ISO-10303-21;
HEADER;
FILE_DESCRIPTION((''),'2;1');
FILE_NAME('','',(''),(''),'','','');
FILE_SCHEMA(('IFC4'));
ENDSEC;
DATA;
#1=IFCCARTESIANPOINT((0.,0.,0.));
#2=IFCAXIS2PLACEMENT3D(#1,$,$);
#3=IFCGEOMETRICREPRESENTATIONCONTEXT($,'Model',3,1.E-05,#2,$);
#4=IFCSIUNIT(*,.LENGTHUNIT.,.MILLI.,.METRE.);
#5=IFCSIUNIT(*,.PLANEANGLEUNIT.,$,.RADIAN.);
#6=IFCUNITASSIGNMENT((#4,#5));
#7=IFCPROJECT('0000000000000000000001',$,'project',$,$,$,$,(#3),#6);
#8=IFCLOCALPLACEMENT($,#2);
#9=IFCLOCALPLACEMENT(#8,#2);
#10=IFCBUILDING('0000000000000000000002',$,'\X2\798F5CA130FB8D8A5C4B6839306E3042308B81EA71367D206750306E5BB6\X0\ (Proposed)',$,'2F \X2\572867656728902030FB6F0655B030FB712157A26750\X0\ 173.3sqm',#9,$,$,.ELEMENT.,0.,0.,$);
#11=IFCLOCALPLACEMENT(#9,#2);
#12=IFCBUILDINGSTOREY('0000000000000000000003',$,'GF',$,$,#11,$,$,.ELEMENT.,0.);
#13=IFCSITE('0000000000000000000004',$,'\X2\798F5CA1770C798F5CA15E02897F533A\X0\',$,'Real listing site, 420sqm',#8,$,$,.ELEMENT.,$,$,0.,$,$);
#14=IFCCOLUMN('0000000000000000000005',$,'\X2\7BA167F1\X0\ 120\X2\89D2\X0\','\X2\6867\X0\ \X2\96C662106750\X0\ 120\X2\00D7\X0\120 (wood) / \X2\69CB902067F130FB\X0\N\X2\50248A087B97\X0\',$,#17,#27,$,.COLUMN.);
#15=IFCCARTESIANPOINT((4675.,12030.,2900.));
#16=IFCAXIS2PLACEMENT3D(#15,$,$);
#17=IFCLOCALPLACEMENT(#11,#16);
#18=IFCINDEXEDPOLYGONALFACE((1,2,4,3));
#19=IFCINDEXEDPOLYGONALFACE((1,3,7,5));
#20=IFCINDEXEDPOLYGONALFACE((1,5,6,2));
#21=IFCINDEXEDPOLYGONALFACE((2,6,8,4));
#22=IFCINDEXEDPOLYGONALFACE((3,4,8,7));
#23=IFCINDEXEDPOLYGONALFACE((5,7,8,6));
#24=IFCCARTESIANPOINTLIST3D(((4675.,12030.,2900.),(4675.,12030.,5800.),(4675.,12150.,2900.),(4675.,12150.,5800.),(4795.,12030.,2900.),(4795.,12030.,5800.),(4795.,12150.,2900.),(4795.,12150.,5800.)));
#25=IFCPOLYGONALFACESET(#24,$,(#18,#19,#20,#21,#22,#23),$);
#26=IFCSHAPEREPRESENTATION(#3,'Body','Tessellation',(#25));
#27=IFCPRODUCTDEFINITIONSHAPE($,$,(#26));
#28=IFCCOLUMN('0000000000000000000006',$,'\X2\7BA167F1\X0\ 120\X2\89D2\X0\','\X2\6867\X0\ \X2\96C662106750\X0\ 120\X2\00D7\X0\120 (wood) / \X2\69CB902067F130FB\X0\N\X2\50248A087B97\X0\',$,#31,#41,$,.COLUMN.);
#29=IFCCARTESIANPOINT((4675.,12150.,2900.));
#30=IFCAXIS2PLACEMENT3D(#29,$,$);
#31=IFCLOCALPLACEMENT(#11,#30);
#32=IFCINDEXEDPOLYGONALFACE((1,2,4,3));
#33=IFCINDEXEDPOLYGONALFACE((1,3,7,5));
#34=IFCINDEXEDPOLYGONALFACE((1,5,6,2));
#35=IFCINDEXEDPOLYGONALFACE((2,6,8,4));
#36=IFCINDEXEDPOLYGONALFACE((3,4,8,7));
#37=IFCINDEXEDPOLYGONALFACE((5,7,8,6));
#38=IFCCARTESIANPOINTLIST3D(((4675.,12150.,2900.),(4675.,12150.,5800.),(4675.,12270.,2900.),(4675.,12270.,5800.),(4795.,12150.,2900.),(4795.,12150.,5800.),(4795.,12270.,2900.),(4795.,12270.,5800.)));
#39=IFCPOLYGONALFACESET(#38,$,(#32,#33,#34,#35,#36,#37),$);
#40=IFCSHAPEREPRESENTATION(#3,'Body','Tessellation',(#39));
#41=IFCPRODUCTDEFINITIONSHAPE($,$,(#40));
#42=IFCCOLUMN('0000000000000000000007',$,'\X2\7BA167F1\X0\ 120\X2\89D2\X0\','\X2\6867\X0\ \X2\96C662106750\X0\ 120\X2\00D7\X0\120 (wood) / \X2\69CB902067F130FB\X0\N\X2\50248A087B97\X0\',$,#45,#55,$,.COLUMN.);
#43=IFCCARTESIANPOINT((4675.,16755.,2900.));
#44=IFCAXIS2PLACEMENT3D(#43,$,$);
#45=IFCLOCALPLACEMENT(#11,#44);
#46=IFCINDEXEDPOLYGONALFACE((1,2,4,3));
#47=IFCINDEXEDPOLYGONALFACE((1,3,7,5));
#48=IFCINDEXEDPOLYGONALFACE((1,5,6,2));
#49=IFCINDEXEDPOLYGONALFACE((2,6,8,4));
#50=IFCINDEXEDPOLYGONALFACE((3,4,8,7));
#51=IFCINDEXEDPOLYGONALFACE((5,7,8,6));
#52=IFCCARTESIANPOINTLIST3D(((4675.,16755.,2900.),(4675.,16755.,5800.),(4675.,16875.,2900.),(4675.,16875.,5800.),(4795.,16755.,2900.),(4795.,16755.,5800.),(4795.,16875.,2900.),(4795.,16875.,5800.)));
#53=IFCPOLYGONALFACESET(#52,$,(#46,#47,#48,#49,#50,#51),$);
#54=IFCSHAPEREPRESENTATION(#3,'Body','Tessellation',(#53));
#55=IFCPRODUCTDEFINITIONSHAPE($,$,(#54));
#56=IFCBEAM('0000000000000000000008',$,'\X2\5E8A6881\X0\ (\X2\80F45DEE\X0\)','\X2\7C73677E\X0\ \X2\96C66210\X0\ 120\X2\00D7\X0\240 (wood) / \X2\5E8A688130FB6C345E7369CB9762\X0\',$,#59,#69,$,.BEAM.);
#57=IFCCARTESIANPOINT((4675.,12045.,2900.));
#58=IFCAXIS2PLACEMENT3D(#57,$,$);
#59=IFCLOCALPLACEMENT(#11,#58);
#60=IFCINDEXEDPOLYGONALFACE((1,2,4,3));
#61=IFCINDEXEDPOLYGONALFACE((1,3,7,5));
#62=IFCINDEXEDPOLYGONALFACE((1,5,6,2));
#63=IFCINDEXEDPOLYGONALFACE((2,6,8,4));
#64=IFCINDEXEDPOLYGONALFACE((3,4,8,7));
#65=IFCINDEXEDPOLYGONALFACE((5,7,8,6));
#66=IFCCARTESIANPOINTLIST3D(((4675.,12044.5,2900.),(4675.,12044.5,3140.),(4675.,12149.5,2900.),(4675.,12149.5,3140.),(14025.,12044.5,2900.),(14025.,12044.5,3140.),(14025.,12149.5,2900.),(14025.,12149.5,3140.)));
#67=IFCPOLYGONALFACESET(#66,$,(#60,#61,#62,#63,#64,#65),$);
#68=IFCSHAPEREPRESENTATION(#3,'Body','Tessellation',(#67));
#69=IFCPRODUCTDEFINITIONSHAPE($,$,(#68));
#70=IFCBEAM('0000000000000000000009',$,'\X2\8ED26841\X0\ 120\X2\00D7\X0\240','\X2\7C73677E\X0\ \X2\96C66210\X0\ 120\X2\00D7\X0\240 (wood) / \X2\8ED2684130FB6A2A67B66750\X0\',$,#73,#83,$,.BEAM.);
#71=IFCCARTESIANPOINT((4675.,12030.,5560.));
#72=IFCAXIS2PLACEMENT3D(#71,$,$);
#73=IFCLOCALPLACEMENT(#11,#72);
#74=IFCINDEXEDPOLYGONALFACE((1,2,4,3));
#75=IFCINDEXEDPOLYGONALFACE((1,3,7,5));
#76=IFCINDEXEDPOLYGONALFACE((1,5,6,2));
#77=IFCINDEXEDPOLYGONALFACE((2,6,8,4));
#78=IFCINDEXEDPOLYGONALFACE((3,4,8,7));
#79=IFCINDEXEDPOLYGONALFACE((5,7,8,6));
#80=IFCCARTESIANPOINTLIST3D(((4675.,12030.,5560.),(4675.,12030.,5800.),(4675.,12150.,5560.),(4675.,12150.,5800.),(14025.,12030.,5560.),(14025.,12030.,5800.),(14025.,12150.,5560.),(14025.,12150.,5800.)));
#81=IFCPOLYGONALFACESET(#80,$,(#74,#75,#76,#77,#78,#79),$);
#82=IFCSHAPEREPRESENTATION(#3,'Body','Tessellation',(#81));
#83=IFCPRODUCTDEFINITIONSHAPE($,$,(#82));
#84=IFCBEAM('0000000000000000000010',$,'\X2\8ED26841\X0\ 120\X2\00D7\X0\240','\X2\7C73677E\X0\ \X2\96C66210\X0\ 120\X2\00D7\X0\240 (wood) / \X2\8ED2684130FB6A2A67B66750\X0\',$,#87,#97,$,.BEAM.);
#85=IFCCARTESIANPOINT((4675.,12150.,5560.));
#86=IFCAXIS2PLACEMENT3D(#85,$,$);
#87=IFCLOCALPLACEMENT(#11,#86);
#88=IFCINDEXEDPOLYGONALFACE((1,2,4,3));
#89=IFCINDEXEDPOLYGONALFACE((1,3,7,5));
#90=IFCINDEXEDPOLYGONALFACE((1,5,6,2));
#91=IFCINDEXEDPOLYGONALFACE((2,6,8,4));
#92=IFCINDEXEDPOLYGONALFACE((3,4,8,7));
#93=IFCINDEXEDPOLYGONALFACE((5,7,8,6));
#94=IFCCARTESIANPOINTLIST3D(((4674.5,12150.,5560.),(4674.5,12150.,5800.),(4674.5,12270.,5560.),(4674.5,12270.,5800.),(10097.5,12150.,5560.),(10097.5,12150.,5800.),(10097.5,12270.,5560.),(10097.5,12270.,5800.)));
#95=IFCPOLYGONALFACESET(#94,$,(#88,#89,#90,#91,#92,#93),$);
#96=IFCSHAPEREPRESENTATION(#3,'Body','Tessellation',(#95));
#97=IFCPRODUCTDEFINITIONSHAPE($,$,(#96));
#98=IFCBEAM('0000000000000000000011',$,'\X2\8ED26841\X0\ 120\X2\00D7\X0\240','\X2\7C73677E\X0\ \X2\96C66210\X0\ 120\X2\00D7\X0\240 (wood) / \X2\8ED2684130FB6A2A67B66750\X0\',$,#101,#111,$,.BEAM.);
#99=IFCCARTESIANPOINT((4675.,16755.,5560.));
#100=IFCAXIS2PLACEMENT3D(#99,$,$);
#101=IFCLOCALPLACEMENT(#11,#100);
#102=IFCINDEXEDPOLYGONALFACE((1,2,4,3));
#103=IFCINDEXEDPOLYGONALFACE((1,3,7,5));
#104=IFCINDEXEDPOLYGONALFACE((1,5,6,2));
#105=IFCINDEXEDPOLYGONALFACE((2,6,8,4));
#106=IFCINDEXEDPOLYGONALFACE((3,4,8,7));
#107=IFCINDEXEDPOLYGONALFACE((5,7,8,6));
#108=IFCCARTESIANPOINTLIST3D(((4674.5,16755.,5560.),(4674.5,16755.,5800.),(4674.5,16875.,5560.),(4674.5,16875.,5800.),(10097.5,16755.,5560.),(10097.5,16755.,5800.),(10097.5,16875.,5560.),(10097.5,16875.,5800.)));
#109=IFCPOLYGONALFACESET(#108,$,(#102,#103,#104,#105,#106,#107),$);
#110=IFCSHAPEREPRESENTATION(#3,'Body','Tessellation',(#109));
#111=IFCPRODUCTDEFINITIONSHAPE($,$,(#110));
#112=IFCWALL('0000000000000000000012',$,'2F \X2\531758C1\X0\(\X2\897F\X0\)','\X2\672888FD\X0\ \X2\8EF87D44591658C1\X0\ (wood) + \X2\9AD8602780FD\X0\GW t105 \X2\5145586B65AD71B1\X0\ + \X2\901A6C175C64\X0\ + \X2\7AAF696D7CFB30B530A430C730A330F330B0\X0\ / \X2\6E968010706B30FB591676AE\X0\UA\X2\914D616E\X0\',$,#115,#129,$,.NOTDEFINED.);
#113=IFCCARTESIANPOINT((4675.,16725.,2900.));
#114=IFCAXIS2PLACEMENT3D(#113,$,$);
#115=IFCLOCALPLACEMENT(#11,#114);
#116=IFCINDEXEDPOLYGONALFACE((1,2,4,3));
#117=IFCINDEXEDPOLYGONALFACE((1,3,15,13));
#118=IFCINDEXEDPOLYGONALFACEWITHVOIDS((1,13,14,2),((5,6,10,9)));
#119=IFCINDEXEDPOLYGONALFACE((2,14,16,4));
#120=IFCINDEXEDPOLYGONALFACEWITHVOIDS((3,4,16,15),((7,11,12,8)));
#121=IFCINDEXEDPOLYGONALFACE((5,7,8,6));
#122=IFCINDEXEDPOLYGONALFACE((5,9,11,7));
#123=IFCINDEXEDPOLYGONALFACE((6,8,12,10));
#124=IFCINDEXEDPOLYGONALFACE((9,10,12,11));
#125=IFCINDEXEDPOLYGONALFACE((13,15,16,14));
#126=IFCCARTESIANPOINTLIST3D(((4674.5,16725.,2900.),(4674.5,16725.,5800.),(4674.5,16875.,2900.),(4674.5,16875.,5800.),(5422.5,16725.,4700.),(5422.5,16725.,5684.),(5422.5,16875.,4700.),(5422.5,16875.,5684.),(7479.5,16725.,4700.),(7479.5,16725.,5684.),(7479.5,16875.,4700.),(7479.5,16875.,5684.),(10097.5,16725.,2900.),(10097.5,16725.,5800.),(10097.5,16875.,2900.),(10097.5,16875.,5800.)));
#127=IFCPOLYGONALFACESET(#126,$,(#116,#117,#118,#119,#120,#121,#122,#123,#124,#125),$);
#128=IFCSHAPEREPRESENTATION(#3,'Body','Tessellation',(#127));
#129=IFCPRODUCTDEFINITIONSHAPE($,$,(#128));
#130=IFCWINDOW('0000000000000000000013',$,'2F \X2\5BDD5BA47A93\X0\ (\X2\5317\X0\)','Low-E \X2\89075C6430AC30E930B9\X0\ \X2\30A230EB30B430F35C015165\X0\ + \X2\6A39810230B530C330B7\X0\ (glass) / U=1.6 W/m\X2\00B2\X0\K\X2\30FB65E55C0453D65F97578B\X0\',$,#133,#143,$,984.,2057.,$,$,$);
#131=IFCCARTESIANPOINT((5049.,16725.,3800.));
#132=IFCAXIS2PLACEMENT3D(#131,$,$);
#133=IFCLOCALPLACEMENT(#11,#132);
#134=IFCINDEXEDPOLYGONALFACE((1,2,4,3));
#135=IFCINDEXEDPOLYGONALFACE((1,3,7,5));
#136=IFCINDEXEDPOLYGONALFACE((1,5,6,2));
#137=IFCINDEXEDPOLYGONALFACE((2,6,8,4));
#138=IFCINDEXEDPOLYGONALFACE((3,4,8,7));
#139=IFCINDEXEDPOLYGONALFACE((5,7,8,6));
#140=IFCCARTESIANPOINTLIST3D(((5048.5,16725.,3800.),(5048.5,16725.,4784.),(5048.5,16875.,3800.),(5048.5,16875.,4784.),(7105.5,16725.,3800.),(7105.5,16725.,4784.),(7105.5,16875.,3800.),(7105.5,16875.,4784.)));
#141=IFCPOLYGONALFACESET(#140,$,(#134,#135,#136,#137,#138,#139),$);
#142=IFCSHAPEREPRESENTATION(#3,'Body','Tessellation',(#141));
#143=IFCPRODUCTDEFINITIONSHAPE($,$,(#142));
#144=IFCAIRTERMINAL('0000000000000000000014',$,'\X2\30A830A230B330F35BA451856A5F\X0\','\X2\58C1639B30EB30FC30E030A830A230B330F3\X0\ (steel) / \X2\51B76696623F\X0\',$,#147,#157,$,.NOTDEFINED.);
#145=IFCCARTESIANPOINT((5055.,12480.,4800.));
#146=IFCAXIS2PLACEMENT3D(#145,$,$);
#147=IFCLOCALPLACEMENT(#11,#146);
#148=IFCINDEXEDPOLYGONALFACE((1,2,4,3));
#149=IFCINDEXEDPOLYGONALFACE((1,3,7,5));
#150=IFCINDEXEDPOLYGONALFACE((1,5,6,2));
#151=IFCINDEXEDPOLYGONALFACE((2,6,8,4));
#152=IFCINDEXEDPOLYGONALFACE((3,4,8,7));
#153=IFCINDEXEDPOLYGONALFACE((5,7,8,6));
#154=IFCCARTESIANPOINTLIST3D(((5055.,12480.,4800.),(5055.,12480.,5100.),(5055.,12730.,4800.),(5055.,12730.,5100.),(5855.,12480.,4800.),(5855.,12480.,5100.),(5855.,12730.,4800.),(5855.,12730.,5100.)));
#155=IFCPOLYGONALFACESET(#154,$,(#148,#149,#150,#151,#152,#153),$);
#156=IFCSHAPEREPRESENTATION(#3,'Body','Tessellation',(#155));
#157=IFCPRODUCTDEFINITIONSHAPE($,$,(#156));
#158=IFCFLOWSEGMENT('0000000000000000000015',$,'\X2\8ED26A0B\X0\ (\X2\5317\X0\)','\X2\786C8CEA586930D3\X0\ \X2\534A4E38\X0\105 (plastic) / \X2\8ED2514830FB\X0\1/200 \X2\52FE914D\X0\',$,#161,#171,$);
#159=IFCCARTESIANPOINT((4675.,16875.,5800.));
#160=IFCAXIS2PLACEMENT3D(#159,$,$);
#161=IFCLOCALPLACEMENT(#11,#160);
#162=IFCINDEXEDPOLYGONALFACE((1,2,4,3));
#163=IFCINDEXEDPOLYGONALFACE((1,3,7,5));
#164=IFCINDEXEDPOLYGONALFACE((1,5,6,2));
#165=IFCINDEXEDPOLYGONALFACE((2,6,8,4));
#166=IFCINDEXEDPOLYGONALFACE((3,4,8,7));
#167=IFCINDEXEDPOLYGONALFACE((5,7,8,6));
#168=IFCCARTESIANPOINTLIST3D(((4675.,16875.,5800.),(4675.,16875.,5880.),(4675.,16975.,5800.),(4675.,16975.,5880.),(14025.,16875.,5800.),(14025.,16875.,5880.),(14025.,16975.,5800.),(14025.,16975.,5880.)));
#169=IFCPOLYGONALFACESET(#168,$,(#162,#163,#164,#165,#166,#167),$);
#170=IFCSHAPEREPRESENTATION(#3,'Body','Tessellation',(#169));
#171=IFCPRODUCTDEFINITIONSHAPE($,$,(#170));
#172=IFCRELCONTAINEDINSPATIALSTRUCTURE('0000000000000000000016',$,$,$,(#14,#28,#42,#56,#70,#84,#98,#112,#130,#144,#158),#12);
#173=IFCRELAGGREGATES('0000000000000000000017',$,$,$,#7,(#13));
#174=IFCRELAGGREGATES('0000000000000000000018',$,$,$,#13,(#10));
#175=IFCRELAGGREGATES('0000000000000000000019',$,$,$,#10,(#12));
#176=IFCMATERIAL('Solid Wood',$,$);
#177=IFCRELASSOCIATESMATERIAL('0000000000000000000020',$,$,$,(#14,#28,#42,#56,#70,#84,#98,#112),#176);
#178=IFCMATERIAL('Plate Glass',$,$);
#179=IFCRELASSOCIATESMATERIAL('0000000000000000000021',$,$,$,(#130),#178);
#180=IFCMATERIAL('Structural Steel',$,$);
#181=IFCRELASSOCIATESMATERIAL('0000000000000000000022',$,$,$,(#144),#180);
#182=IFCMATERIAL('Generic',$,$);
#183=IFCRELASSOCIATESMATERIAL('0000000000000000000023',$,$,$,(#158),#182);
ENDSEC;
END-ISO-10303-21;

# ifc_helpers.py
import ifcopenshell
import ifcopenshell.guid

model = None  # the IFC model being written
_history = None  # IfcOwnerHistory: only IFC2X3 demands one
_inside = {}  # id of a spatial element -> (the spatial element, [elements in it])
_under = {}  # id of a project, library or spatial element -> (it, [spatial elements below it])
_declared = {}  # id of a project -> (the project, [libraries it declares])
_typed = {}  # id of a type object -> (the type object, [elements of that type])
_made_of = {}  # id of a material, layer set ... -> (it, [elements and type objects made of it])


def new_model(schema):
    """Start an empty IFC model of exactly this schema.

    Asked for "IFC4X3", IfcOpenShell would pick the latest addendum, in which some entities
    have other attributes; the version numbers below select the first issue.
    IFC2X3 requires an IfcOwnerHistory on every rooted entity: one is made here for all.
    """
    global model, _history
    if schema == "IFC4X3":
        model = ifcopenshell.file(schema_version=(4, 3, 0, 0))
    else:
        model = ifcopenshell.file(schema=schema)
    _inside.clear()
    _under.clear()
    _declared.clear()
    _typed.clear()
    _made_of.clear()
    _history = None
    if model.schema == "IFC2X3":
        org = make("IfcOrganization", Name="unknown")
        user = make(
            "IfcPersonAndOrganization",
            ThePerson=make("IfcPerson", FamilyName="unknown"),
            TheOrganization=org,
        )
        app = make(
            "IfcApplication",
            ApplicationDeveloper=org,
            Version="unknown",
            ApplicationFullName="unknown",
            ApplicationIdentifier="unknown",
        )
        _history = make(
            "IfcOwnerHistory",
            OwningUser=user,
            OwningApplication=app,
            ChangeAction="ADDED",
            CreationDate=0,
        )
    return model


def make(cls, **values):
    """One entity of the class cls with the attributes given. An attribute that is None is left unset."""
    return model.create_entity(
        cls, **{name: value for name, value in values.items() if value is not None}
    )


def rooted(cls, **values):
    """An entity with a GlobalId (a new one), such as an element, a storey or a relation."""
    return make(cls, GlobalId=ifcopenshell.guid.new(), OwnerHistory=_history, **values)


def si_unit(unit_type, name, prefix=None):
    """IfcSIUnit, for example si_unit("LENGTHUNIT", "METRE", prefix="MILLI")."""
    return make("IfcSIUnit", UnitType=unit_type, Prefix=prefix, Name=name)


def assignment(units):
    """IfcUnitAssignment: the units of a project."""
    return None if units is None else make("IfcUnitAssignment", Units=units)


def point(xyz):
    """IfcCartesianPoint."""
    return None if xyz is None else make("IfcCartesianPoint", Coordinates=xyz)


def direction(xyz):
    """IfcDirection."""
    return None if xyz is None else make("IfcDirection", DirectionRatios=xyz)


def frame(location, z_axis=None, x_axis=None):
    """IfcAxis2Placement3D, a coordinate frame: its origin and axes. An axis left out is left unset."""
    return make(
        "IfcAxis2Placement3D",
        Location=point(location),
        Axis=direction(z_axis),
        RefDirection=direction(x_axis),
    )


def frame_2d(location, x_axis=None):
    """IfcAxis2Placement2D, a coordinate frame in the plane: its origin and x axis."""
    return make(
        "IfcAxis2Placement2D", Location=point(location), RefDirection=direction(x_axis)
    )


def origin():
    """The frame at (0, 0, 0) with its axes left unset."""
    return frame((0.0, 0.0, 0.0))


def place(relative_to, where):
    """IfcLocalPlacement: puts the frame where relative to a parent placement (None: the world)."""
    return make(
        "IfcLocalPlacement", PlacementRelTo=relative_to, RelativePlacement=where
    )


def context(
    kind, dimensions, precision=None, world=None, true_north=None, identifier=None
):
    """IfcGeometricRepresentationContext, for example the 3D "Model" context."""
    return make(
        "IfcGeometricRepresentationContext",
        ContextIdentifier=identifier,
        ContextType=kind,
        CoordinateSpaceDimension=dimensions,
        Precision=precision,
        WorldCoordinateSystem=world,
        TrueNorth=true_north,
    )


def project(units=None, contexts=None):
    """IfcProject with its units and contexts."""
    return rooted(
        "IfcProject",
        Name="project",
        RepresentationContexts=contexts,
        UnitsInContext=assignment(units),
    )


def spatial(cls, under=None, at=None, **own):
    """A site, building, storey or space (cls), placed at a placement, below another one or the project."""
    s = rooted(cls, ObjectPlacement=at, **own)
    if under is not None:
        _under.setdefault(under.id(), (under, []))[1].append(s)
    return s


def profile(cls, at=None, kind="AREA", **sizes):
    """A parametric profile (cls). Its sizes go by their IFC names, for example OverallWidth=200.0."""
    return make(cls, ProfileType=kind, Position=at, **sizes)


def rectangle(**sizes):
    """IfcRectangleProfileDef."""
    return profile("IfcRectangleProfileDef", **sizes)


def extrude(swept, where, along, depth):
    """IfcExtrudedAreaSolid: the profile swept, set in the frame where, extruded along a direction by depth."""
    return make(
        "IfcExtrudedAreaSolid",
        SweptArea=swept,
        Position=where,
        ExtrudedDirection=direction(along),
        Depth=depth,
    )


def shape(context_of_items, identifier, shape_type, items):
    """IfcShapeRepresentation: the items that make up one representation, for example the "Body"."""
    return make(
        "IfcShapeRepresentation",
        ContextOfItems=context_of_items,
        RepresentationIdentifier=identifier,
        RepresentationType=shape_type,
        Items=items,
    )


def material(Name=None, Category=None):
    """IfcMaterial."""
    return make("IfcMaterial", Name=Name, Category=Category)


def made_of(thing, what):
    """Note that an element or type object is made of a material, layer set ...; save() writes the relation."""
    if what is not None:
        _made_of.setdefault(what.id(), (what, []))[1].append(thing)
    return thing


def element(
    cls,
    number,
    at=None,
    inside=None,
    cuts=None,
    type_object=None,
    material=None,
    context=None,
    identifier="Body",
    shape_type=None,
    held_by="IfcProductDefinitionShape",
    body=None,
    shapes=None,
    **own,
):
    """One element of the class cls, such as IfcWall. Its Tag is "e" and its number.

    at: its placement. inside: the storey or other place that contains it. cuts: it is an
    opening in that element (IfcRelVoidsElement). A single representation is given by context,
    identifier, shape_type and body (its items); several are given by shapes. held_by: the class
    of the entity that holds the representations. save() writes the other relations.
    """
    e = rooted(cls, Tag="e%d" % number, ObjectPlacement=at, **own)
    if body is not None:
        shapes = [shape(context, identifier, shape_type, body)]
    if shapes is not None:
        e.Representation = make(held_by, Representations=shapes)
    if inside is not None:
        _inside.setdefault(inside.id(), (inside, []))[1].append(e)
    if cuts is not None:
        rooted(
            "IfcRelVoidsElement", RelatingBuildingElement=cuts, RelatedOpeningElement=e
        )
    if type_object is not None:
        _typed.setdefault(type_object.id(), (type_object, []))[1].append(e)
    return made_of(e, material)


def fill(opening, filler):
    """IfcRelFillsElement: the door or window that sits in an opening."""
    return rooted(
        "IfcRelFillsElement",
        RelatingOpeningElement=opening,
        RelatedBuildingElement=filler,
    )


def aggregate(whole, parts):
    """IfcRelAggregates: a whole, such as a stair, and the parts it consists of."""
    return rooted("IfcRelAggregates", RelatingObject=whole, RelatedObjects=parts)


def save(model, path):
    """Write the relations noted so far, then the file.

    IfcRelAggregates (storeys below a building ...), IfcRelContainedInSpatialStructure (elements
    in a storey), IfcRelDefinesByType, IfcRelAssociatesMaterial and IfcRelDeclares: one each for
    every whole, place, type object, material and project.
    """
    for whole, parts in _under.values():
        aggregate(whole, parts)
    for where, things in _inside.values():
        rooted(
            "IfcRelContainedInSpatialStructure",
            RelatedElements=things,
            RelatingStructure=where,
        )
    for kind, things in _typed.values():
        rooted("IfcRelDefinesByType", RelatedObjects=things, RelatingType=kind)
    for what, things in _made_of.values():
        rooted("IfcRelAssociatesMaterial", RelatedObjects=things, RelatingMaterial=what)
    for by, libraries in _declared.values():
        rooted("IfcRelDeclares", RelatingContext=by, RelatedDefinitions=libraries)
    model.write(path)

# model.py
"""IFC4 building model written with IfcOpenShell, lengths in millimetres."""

from ifc_helpers import new_model, si_unit, frame, frame_2d, origin, place, context, project, spatial, rectangle, extrude, material, element, fill, save


model = new_model("IFC4")

# Units and contexts
model_context = context("Model", 3, precision=1e-05, world=origin())
ifc_project = project(units=[si_unit("LENGTHUNIT", "METRE", prefix="MILLI"), si_unit("PLANEANGLEUNIT", "RADIAN")], contexts=[model_context])

# Site, building, storey
site_placement = place(None, origin())
site = spatial("IfcSite", under=ifc_project, at=site_placement, Name="福岡県福岡市西区", ObjectType="Real listing site, 420sqm", CompositionType="ELEMENT", RefElevation=0.0)
building_placement = place(site_placement, origin())
building = spatial("IfcBuilding", under=site, at=building_placement, Name="福岡・越屋根のある自然素材の家 (Proposed)", ObjectType="2F 在来木造・漆喰・無垢材 173.3sqm", CompositionType="ELEMENT", ElevationOfRefHeight=0.0, ElevationOfTerrain=0.0)
storey_placement = place(building_placement, origin())
storey = spatial("IfcBuildingStorey", under=building, at=storey_placement, Name="GF", CompositionType="ELEMENT", Elevation=0.0)

# Columns
ifc_material_1 = material(Name="Solid Wood")
column_1_placement = place(storey_placement, frame((4675.0, 12030.0, 2900.0)))
element("IfcColumn", 1, at=column_1_placement, inside=storey, material=ifc_material_1, Name="管柱 120角", Description="桧 集成材 120×120 (wood) / 構造柱・N値計算", PredefinedType="COLUMN", context=model_context, shape_type="SweptSolid", body=[
    extrude(rectangle(XDim=120.0, YDim=120.0, at=frame_2d((60.0, 60.0))), frame((4675.0, 12030.0, 2900.0)), (0.0, 0.0, 1.0), 2900.0),
])
column_2_placement = place(storey_placement, frame((4675.0, 12150.0, 2900.0)))
element("IfcColumn", 2, at=column_2_placement, inside=storey, material=ifc_material_1, Name="管柱 120角", Description="桧 集成材 120×120 (wood) / 構造柱・N値計算", PredefinedType="COLUMN", context=model_context, shape_type="SweptSolid", body=[
    extrude(rectangle(XDim=120.0, YDim=120.0, at=frame_2d((60.0, 60.0))), frame((4675.0, 12150.0, 2900.0)), (0.0, 0.0, 1.0), 2900.0),
])
column_3_placement = place(storey_placement, frame((4675.0, 16755.0, 2900.0)))
element("IfcColumn", 3, at=column_3_placement, inside=storey, material=ifc_material_1, Name="管柱 120角", Description="桧 集成材 120×120 (wood) / 構造柱・N値計算", PredefinedType="COLUMN", context=model_context, shape_type="SweptSolid", body=[
    extrude(rectangle(XDim=120.0, YDim=120.0, at=frame_2d((60.0, 60.0))), frame((4675.0, 16755.0, 2900.0)), (0.0, 0.0, 1.0), 2900.0),
])

# Beams
beam_1_placement = place(storey_placement, frame((4675.0, 12045.0, 2900.0)))
element("IfcBeam", 4, at=beam_1_placement, inside=storey, material=ifc_material_1, Name="床梁 (胴差)", Description="米松 集成 120×240 (wood) / 床梁・水平構面", PredefinedType="BEAM", context=model_context, shape_type="SweptSolid", body=[
    extrude(rectangle(XDim=9350.0, YDim=105.0, at=frame_2d((4675.0, 52.0))), frame((4675.0, 12045.0, 2900.0)), (0.0, 0.0, 1.0), 240.0),
])
beam_2_placement = place(storey_placement, frame((4675.0, 12030.0, 5560.0)))
element("IfcBeam", 5, at=beam_2_placement, inside=storey, material=ifc_material_1, Name="軒桁 120×240", Description="米松 集成 120×240 (wood) / 軒桁・横架材", PredefinedType="BEAM", context=model_context, shape_type="SweptSolid", body=[
    extrude(rectangle(XDim=9350.0, YDim=120.0, at=frame_2d((4675.0, 60.0))), frame((4675.0, 12030.0, 5560.0)), (0.0, 0.0, 1.0), 240.0),
])
beam_3_placement = place(storey_placement, frame((4675.0, 12150.0, 5560.0)))
element("IfcBeam", 6, at=beam_3_placement, inside=storey, material=ifc_material_1, Name="軒桁 120×240", Description="米松 集成 120×240 (wood) / 軒桁・横架材", PredefinedType="BEAM", context=model_context, shape_type="SweptSolid", body=[
    extrude(rectangle(XDim=5423.0, YDim=120.0, at=frame_2d((2711.0, 60.0))), frame((4675.0, 12150.0, 5560.0)), (0.0, 0.0, 1.0), 240.0),
])
beam_4_placement = place(storey_placement, frame((4675.0, 16755.0, 5560.0)))
element("IfcBeam", 7, at=beam_4_placement, inside=storey, material=ifc_material_1, Name="軒桁 120×240", Description="米松 集成 120×240 (wood) / 軒桁・横架材", PredefinedType="BEAM", context=model_context, shape_type="SweptSolid", body=[
    extrude(rectangle(XDim=5423.0, YDim=120.0, at=frame_2d((2711.0, 60.0))), frame((4675.0, 16755.0, 5560.0)), (0.0, 0.0, 1.0), 240.0),
])

# Wall, opening, window
wall_1_placement = place(storey_placement, frame((4675.0, 16725.0, 2900.0)))
wall_1 = element("IfcWall", 8, at=wall_1_placement, inside=storey, material=ifc_material_1, Name="2F 北壁(西)", Description="木製 軸組外壁 (wood) + 高性能GW t105 充填断熱 + 通気層 + 窯業系サイディング / 準耐火・外皮UA配慮", PredefinedType="NOTDEFINED", context=model_context, shape_type="SweptSolid", body=[
    extrude(rectangle(XDim=5423.0, YDim=150.0, at=frame_2d((2711.0, 75.0))), frame((4675.0, 16725.0, 2900.0)), (0.0, 0.0, 1.0), 2900.0),
])
opening_placement = place(storey_placement, frame((5049.0, 16725.0, 3800.0)))
opening = element("IfcOpeningElement", 9, at=opening_placement, cuts=wall_1, PredefinedType="NOTDEFINED", context=model_context, shape_type="SweptSolid", body=[
    extrude(rectangle(XDim=2057.0, YDim=150.0, at=frame_2d((1028.0, 75.0))), frame((5049.0, 16725.0, 3800.0)), (0.0, 0.0, 1.0), 984.0),
])
ifc_material_2 = material(Name="Plate Glass")
window_placement = place(storey_placement, frame((5049.0, 16725.0, 3800.0)))
window = element("IfcWindow", 10, at=window_placement, inside=storey, material=ifc_material_2, Name="2F 寝室窓 (北)", Description="Low-E 複層ガラス アルゴン封入 + 樹脂サッシ (glass) / U=1.6 W/m²K・日射取得型", OverallHeight=984.0, OverallWidth=2057.0, context=model_context, shape_type="SweptSolid", body=[
    extrude(rectangle(XDim=2057.0, YDim=150.0, at=frame_2d((1028.0, 75.0))), frame((5049.0, 16725.0, 3800.0)), (0.0, 0.0, 1.0), 984.0),
])
fill(opening, window)

# Shared definitions
ifc_material_3 = material(Name="Structural Steel")

# Shared definitions
ifc_material_4 = material(Name="Generic")

# Air terminal
air_terminal_placement = place(storey_placement, frame((5055.0, 12480.0, 4800.0)))
element("IfcAirTerminal", 11, at=air_terminal_placement, inside=storey, material=ifc_material_3, Name="エアコン室内機", Description="壁掛ルームエアコン (steel) / 冷暖房", PredefinedType="NOTDEFINED", context=model_context, shape_type="SweptSolid", body=[
    extrude(rectangle(XDim=800.0, YDim=250.0, at=frame_2d((400.0, 125.0))), frame((5055.0, 12480.0, 4800.0)), (0.0, 0.0, 1.0), 300.0),
])

# Flow segment
flow_segment_placement = place(storey_placement, frame((4675.0, 16875.0, 5800.0)))
element("IfcFlowSegment", 12, at=flow_segment_placement, inside=storey, material=ifc_material_4, Name="軒樋 (北)", Description="硬質塩ビ 半丸105 (plastic) / 軒先・1/200 勾配", context=model_context, shape_type="SweptSolid", body=[
    extrude(rectangle(XDim=9350.0, YDim=100.0, at=frame_2d((4675.0, 50.0))), frame((4675.0, 16875.0, 5800.0)), (0.0, 0.0, 1.0), 80.0),
])

save(model, "model.ifc")
